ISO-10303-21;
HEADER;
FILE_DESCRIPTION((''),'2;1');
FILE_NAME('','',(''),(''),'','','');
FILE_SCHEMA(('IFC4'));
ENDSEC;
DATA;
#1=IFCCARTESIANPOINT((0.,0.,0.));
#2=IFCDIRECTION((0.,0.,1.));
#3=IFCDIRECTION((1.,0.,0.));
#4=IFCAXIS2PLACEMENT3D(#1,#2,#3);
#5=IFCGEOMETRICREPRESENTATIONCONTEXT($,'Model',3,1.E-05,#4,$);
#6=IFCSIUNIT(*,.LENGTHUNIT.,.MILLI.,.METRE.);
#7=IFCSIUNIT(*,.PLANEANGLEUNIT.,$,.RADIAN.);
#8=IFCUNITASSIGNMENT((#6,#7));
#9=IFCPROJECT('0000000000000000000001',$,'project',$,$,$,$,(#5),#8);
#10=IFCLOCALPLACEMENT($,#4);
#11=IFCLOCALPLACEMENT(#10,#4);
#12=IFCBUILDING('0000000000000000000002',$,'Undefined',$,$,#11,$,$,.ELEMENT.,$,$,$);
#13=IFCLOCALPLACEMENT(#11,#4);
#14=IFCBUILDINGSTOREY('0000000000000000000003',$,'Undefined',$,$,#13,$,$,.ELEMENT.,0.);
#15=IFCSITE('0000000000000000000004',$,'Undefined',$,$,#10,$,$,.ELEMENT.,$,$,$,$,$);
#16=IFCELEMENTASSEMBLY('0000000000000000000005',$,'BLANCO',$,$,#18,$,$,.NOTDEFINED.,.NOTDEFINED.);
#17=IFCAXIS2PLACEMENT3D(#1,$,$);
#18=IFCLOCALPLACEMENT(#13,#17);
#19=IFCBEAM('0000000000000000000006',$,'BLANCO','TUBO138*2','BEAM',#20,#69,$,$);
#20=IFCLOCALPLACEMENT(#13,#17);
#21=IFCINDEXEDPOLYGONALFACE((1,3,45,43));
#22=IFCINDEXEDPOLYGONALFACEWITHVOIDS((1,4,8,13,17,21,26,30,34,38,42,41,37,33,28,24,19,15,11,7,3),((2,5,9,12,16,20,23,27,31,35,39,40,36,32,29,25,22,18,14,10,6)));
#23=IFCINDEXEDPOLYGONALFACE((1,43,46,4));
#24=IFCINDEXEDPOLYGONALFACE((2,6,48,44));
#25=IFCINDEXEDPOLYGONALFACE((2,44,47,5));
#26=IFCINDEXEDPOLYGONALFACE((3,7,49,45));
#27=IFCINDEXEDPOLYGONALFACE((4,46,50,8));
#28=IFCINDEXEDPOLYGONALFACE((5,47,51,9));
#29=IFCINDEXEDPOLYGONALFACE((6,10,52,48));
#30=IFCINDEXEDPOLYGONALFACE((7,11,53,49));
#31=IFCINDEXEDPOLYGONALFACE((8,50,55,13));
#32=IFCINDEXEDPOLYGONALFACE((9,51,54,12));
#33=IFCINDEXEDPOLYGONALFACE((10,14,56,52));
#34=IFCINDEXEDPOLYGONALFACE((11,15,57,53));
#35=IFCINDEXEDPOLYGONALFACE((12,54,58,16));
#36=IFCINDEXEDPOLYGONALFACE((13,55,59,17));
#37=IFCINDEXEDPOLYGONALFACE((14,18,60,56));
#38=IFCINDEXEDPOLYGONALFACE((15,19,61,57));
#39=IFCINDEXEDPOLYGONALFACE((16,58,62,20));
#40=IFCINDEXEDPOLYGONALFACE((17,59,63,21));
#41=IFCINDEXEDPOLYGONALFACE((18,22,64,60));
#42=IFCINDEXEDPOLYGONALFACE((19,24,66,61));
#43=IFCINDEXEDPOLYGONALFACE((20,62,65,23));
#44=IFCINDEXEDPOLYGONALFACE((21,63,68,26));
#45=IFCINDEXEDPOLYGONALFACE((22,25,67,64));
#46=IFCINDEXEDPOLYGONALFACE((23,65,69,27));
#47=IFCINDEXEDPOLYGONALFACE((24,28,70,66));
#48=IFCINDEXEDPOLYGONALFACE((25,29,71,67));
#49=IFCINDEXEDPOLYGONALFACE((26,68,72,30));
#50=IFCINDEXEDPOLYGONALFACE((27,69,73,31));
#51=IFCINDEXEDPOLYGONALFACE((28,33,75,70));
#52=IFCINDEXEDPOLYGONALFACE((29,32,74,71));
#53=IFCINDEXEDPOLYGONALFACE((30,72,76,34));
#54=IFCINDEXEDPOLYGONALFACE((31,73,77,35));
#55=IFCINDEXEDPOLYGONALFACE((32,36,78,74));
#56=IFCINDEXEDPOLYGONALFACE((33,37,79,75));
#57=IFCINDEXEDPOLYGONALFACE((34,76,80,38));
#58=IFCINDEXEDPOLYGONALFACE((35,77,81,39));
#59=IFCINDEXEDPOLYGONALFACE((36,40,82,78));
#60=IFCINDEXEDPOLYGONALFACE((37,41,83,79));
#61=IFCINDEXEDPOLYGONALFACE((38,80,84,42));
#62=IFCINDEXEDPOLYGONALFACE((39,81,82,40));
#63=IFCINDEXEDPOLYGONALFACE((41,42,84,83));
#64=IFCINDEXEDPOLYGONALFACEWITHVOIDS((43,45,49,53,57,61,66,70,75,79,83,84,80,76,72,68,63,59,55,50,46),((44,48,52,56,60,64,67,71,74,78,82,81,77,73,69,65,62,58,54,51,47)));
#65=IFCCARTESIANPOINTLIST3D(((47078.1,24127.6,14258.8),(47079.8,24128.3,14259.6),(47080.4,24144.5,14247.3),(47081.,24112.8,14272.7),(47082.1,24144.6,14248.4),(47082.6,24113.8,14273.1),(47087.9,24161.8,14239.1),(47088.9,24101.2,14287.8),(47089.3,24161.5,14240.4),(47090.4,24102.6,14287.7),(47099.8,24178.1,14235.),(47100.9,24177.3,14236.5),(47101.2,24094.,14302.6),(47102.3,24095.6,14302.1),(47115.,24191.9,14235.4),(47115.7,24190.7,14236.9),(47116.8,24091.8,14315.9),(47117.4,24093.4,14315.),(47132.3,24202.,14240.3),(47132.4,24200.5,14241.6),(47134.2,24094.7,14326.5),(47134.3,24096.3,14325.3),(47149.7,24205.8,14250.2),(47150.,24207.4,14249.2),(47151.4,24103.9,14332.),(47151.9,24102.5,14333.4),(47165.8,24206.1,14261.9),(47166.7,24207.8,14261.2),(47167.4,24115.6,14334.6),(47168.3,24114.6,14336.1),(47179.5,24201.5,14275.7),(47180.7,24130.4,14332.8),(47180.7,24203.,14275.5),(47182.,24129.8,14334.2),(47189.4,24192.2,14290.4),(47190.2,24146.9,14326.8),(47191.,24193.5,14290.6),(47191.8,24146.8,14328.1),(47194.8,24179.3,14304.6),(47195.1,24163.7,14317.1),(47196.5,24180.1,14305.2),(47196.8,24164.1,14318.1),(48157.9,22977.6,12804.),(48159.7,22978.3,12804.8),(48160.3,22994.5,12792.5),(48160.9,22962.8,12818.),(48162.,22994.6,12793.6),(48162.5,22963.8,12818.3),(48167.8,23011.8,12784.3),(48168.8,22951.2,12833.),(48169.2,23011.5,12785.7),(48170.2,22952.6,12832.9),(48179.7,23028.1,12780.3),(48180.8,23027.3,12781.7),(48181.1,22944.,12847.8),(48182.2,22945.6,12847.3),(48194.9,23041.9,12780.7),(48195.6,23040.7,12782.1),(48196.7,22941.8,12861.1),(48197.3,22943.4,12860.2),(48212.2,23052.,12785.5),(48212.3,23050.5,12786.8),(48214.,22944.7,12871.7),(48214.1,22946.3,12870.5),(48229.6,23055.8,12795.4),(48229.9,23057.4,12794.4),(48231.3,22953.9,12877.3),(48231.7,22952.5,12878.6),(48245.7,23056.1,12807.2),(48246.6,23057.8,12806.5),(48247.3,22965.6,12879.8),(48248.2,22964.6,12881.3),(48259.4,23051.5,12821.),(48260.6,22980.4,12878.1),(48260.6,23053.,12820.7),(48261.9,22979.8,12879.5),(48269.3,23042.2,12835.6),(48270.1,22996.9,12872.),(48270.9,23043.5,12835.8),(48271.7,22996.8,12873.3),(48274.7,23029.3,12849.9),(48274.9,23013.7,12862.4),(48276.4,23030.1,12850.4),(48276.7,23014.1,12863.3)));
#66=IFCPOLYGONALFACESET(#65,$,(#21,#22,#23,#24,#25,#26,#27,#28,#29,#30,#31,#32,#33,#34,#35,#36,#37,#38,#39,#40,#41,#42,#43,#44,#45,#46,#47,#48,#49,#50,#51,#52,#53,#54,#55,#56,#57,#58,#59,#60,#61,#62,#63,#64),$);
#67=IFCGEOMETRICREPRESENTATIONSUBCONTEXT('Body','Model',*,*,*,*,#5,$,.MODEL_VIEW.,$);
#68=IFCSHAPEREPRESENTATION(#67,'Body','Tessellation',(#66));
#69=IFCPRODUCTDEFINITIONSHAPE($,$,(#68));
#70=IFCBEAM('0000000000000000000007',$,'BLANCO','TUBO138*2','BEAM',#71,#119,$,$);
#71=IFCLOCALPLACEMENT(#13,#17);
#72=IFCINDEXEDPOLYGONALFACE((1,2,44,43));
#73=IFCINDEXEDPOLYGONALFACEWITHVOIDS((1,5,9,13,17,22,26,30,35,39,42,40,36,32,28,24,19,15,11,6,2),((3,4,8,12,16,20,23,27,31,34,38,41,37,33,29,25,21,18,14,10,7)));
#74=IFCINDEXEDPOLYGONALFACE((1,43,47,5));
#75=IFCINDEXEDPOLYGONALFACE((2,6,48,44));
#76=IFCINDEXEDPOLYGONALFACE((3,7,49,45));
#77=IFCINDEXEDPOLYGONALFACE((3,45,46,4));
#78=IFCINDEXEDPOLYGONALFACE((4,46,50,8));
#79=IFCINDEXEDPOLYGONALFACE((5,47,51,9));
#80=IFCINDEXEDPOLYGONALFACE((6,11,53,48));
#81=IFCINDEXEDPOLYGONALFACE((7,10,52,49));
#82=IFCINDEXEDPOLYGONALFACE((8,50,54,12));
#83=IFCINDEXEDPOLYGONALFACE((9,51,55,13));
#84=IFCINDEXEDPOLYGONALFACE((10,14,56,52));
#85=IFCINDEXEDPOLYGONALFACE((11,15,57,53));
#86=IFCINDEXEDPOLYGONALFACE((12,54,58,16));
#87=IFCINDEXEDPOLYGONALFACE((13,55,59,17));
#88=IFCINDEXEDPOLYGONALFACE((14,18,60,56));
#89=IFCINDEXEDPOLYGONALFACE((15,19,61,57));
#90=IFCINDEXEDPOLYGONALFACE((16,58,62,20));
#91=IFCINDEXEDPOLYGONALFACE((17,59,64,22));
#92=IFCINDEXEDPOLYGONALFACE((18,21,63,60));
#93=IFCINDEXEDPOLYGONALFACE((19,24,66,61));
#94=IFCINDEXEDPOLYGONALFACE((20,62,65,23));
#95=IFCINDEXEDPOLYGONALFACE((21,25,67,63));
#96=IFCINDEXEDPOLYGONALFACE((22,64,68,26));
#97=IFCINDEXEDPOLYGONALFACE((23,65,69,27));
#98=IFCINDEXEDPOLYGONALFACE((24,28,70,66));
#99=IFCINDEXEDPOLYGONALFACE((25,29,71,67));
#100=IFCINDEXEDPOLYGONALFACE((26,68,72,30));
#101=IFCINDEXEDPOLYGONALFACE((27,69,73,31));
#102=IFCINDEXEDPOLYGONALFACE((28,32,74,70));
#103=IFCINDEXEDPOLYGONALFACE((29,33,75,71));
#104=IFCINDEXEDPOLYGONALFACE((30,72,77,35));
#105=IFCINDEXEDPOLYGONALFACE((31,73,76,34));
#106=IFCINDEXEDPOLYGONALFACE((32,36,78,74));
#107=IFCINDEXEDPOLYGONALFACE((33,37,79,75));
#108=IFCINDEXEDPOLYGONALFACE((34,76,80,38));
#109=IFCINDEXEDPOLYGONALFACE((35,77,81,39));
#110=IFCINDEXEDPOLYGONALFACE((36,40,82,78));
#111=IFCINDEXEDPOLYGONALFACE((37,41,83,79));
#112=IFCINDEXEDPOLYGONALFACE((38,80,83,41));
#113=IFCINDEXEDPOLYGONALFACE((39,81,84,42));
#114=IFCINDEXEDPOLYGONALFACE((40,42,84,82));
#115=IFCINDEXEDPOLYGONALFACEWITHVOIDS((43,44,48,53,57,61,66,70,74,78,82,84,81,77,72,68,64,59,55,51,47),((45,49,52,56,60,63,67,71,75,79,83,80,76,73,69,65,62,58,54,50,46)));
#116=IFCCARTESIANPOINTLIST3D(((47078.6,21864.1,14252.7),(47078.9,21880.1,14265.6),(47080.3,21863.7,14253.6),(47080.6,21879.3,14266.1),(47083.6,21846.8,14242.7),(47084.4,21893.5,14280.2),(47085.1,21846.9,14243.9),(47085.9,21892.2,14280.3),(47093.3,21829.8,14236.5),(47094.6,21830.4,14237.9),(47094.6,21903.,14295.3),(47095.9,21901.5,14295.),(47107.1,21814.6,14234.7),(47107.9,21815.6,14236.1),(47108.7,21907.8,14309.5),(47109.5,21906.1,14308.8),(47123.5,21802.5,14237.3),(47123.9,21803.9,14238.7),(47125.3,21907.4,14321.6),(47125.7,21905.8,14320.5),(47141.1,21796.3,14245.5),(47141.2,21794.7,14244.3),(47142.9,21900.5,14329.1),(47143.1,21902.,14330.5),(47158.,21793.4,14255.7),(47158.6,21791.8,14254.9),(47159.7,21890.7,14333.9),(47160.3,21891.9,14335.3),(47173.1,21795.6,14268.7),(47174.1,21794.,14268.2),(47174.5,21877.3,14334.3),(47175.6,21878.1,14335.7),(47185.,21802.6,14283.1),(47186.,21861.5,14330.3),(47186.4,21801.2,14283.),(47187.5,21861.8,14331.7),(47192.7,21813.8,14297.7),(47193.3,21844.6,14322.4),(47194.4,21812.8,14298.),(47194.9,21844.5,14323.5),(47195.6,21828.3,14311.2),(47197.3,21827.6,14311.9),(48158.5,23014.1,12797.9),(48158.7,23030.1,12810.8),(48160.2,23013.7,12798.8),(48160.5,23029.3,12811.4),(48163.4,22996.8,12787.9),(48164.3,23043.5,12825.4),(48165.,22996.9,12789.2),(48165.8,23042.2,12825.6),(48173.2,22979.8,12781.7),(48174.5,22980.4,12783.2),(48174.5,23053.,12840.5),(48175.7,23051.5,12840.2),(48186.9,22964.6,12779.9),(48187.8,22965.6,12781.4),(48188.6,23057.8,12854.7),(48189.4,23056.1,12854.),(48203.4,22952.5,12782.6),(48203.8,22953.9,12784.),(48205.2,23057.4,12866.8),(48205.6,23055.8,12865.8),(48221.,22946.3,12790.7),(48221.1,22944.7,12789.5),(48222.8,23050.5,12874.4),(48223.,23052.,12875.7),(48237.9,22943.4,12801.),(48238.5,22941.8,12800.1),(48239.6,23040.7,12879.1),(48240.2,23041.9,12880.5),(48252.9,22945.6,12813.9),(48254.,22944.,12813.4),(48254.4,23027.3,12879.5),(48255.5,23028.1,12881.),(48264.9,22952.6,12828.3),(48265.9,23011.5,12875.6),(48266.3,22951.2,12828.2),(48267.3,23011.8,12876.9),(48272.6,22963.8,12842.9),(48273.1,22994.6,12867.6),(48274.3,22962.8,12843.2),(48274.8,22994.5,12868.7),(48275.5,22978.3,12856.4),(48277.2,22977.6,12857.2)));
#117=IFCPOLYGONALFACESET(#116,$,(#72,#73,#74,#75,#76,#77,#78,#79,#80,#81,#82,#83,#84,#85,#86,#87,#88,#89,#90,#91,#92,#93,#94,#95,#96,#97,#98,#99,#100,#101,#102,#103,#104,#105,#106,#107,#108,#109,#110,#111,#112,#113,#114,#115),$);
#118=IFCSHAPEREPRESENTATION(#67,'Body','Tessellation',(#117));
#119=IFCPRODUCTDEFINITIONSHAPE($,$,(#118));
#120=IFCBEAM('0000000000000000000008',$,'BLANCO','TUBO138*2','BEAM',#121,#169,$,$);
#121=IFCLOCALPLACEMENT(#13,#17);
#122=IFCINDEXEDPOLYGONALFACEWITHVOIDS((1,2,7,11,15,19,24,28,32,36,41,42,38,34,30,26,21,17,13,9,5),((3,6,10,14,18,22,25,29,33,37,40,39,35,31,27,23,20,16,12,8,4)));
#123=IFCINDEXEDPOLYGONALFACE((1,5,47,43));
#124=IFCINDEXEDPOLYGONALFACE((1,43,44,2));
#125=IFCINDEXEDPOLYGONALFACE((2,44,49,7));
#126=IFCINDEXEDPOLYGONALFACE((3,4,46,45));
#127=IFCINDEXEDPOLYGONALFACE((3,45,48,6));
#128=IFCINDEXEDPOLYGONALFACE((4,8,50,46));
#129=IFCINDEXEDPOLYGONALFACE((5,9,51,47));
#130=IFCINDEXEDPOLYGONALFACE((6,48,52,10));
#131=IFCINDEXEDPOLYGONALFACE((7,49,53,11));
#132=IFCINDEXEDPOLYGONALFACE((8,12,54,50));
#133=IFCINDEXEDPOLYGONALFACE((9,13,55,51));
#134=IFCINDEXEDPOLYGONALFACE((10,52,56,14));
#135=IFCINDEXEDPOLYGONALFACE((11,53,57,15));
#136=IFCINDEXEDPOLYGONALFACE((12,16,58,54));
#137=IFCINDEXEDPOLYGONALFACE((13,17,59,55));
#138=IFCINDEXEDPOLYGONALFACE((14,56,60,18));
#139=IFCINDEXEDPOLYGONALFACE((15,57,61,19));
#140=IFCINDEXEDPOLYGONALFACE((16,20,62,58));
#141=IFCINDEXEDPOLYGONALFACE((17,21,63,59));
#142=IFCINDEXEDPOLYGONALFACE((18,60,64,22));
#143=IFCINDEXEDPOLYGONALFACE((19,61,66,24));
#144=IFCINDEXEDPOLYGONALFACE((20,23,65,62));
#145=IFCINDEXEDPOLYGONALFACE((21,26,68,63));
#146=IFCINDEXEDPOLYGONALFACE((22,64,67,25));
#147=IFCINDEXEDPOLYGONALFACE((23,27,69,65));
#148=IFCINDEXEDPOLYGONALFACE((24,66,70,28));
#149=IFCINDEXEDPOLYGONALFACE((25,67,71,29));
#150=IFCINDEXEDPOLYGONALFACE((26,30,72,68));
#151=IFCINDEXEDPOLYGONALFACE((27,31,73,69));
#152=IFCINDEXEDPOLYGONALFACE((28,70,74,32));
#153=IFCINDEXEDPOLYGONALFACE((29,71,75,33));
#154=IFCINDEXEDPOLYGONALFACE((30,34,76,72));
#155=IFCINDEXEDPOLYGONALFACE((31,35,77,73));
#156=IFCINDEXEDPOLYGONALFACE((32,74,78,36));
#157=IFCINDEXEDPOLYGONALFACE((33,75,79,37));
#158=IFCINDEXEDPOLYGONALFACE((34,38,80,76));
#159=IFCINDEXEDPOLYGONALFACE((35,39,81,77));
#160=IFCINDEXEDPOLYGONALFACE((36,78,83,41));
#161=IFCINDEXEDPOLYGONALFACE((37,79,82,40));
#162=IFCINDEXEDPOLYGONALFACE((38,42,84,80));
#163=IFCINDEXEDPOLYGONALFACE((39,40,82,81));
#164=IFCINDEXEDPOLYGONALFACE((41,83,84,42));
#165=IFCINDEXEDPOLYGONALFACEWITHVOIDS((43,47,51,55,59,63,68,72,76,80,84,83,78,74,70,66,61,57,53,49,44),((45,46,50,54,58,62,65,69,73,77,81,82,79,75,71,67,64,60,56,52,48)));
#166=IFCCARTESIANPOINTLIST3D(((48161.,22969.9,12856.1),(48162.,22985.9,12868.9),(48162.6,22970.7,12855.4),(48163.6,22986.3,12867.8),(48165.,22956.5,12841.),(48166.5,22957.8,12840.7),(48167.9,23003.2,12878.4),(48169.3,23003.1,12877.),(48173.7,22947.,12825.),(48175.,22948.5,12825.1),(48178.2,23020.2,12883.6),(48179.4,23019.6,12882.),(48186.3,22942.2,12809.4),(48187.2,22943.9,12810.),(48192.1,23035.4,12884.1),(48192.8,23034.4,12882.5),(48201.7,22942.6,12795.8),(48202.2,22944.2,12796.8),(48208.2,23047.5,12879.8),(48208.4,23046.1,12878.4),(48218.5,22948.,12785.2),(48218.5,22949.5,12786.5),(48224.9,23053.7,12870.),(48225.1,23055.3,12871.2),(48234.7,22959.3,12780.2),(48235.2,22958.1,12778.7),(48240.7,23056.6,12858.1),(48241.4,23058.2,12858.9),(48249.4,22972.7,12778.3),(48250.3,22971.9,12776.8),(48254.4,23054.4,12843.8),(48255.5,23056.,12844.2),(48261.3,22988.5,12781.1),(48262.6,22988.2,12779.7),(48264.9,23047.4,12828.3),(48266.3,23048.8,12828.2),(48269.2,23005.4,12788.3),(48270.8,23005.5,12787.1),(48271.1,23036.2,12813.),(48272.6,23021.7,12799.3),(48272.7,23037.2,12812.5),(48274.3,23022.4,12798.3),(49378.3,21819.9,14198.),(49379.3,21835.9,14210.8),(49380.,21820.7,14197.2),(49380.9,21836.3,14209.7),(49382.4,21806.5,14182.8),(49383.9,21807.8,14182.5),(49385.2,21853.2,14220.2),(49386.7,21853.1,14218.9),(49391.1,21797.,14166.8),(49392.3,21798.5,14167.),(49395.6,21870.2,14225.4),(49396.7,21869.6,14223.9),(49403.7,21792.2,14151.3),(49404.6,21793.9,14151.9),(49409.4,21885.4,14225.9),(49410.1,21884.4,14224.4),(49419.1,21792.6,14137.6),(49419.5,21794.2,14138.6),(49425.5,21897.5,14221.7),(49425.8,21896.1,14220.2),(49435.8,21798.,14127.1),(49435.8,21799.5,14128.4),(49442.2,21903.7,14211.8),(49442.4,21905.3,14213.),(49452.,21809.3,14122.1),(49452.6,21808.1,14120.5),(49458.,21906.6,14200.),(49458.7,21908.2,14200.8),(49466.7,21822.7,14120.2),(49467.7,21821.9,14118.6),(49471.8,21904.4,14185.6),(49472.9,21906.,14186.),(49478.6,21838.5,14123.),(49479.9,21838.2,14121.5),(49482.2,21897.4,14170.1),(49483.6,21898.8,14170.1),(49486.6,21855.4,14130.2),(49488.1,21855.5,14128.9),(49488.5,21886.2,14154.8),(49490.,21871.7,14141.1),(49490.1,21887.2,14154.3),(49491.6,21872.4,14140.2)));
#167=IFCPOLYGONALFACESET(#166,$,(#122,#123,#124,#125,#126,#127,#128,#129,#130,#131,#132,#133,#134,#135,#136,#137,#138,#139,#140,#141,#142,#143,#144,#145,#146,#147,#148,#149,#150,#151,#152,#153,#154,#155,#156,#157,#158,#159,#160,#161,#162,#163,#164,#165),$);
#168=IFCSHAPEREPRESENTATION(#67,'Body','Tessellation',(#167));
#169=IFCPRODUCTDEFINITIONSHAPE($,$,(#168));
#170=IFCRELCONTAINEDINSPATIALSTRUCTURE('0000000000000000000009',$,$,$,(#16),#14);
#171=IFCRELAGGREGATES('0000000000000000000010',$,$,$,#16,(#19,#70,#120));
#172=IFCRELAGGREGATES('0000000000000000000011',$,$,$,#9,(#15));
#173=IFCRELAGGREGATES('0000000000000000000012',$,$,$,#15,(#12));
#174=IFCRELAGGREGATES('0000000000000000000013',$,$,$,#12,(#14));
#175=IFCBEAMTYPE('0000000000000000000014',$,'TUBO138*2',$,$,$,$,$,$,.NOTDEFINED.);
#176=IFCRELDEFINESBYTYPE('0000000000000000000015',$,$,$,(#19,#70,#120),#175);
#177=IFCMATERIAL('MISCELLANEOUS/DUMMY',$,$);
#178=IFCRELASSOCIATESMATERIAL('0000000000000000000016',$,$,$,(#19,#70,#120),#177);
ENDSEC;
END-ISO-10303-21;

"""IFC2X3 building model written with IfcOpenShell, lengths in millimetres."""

from ifc_helpers import new_model, si_unit, frame, origin_with_axes, origin_2d_with_axis, place, context, subcontext, project, spatial, hollow_circle, extrude, material, type_object, element, aggregate, save


model = new_model("IFC2X3")

# Units and contexts
model_context = context("Model", 3, precision=1e-05, world=origin_with_axes())
body_context = subcontext(model_context, "Body", "Model", "MODEL_VIEW")
ifc_project = project(units=[si_unit("LENGTHUNIT", "METRE", prefix="MILLI"), si_unit("PLANEANGLEUNIT", "RADIAN")], contexts=[model_context])

# Site, building, storey
site_placement = place(None, origin_with_axes())
site = spatial("IfcSite", under=ifc_project, at=site_placement, Name="Undefined", CompositionType="ELEMENT")
building_placement = place(site_placement, origin_with_axes())
building = spatial("IfcBuilding", under=site, at=building_placement, Name="Undefined", CompositionType="ELEMENT")
storey_placement = place(building_placement, origin_with_axes())
storey = spatial("IfcBuildingStorey", under=building, at=storey_placement, Name="Undefined", CompositionType="ELEMENT", Elevation=0.0)

# Element assembly, beams
assembly_placement = place(storey_placement, origin_with_axes())
assembly = element("IfcElementAssembly", 1, at=assembly_placement, inside=storey, Name="BLANCO", AssemblyPlace="NOTDEFINED", PredefinedType="NOTDEFINED")
ifc_material = material(Name="MISCELLANEOUS/DUMMY")
beam_type = type_object("IfcBeamType", Name="TUBO138*2", PredefinedType="NOTDEFINED")
beam_1_placement = place(assembly_placement, frame((48217.6, 23000.0, 12830.6), z_axis=(-0.497966, 0.461316, -0.734314), x_axis=(-0.503224, 0.535899, 0.677922)))
beam_1 = element("IfcBeam", 2, at=beam_1_placement, type_object=beam_type, material=ifc_material, Name="BLANCO", Description="TUBO138*2", ObjectType="BEAM", context=body_context, shape_type="SweptSolid", body=[
    extrude(hollow_circle(Radius=69.0, WallThickness=2.0, at=origin_2d_with_axis()), frame((2145.9, 0.0, 0.0), z_axis=(-1.0, 0.0, 0.0), x_axis=(0.0, -1.0, 0.0)), (0.0, 0.0, 1.0), 2145.9),
])
beam_2_placement = place(assembly_placement, frame((48217.6, 23000.0, 12830.6), z_axis=(-0.497966, -0.461316, -0.734314), x_axis=(-0.503224, -0.535899, 0.677922)))
beam_2 = element("IfcBeam", 3, at=beam_2_placement, type_object=beam_type, material=ifc_material, Name="BLANCO", Description="TUBO138*2", ObjectType="BEAM", context=body_context, shape_type="SweptSolid", body=[
    extrude(hollow_circle(Radius=69.0, WallThickness=2.0, at=origin_2d_with_axis()), frame((2145.9, 0.0, 0.0), z_axis=(-1.0, 0.0, 0.0), x_axis=(0.0, -1.0, 0.0)), (0.0, 0.0, 1.0), 2145.9),
])
beam_3_placement = place(assembly_placement, frame((48217.6, 23000.0, 12830.6), z_axis=(0.423552, -0.461316, -0.77961), x_axis=(0.567282, -0.535899, 0.625303)))
beam_3 = element("IfcBeam", 4, at=beam_3_placement, type_object=beam_type, material=ifc_material, Name="BLANCO", Description="TUBO138*2", ObjectType="BEAM", context=body_context, shape_type="SweptSolid", body=[
    extrude(hollow_circle(Radius=69.0, WallThickness=2.0, at=origin_2d_with_axis()), frame((2145.9, 0.0, 0.0), z_axis=(-1.0, 0.0, 0.0), x_axis=(0.0, -1.0, 0.0)), (0.0, 0.0, 1.0), 2145.9),
])
aggregate(assembly, [beam_1, beam_2, beam_3])

save(model, "model.ifc")
